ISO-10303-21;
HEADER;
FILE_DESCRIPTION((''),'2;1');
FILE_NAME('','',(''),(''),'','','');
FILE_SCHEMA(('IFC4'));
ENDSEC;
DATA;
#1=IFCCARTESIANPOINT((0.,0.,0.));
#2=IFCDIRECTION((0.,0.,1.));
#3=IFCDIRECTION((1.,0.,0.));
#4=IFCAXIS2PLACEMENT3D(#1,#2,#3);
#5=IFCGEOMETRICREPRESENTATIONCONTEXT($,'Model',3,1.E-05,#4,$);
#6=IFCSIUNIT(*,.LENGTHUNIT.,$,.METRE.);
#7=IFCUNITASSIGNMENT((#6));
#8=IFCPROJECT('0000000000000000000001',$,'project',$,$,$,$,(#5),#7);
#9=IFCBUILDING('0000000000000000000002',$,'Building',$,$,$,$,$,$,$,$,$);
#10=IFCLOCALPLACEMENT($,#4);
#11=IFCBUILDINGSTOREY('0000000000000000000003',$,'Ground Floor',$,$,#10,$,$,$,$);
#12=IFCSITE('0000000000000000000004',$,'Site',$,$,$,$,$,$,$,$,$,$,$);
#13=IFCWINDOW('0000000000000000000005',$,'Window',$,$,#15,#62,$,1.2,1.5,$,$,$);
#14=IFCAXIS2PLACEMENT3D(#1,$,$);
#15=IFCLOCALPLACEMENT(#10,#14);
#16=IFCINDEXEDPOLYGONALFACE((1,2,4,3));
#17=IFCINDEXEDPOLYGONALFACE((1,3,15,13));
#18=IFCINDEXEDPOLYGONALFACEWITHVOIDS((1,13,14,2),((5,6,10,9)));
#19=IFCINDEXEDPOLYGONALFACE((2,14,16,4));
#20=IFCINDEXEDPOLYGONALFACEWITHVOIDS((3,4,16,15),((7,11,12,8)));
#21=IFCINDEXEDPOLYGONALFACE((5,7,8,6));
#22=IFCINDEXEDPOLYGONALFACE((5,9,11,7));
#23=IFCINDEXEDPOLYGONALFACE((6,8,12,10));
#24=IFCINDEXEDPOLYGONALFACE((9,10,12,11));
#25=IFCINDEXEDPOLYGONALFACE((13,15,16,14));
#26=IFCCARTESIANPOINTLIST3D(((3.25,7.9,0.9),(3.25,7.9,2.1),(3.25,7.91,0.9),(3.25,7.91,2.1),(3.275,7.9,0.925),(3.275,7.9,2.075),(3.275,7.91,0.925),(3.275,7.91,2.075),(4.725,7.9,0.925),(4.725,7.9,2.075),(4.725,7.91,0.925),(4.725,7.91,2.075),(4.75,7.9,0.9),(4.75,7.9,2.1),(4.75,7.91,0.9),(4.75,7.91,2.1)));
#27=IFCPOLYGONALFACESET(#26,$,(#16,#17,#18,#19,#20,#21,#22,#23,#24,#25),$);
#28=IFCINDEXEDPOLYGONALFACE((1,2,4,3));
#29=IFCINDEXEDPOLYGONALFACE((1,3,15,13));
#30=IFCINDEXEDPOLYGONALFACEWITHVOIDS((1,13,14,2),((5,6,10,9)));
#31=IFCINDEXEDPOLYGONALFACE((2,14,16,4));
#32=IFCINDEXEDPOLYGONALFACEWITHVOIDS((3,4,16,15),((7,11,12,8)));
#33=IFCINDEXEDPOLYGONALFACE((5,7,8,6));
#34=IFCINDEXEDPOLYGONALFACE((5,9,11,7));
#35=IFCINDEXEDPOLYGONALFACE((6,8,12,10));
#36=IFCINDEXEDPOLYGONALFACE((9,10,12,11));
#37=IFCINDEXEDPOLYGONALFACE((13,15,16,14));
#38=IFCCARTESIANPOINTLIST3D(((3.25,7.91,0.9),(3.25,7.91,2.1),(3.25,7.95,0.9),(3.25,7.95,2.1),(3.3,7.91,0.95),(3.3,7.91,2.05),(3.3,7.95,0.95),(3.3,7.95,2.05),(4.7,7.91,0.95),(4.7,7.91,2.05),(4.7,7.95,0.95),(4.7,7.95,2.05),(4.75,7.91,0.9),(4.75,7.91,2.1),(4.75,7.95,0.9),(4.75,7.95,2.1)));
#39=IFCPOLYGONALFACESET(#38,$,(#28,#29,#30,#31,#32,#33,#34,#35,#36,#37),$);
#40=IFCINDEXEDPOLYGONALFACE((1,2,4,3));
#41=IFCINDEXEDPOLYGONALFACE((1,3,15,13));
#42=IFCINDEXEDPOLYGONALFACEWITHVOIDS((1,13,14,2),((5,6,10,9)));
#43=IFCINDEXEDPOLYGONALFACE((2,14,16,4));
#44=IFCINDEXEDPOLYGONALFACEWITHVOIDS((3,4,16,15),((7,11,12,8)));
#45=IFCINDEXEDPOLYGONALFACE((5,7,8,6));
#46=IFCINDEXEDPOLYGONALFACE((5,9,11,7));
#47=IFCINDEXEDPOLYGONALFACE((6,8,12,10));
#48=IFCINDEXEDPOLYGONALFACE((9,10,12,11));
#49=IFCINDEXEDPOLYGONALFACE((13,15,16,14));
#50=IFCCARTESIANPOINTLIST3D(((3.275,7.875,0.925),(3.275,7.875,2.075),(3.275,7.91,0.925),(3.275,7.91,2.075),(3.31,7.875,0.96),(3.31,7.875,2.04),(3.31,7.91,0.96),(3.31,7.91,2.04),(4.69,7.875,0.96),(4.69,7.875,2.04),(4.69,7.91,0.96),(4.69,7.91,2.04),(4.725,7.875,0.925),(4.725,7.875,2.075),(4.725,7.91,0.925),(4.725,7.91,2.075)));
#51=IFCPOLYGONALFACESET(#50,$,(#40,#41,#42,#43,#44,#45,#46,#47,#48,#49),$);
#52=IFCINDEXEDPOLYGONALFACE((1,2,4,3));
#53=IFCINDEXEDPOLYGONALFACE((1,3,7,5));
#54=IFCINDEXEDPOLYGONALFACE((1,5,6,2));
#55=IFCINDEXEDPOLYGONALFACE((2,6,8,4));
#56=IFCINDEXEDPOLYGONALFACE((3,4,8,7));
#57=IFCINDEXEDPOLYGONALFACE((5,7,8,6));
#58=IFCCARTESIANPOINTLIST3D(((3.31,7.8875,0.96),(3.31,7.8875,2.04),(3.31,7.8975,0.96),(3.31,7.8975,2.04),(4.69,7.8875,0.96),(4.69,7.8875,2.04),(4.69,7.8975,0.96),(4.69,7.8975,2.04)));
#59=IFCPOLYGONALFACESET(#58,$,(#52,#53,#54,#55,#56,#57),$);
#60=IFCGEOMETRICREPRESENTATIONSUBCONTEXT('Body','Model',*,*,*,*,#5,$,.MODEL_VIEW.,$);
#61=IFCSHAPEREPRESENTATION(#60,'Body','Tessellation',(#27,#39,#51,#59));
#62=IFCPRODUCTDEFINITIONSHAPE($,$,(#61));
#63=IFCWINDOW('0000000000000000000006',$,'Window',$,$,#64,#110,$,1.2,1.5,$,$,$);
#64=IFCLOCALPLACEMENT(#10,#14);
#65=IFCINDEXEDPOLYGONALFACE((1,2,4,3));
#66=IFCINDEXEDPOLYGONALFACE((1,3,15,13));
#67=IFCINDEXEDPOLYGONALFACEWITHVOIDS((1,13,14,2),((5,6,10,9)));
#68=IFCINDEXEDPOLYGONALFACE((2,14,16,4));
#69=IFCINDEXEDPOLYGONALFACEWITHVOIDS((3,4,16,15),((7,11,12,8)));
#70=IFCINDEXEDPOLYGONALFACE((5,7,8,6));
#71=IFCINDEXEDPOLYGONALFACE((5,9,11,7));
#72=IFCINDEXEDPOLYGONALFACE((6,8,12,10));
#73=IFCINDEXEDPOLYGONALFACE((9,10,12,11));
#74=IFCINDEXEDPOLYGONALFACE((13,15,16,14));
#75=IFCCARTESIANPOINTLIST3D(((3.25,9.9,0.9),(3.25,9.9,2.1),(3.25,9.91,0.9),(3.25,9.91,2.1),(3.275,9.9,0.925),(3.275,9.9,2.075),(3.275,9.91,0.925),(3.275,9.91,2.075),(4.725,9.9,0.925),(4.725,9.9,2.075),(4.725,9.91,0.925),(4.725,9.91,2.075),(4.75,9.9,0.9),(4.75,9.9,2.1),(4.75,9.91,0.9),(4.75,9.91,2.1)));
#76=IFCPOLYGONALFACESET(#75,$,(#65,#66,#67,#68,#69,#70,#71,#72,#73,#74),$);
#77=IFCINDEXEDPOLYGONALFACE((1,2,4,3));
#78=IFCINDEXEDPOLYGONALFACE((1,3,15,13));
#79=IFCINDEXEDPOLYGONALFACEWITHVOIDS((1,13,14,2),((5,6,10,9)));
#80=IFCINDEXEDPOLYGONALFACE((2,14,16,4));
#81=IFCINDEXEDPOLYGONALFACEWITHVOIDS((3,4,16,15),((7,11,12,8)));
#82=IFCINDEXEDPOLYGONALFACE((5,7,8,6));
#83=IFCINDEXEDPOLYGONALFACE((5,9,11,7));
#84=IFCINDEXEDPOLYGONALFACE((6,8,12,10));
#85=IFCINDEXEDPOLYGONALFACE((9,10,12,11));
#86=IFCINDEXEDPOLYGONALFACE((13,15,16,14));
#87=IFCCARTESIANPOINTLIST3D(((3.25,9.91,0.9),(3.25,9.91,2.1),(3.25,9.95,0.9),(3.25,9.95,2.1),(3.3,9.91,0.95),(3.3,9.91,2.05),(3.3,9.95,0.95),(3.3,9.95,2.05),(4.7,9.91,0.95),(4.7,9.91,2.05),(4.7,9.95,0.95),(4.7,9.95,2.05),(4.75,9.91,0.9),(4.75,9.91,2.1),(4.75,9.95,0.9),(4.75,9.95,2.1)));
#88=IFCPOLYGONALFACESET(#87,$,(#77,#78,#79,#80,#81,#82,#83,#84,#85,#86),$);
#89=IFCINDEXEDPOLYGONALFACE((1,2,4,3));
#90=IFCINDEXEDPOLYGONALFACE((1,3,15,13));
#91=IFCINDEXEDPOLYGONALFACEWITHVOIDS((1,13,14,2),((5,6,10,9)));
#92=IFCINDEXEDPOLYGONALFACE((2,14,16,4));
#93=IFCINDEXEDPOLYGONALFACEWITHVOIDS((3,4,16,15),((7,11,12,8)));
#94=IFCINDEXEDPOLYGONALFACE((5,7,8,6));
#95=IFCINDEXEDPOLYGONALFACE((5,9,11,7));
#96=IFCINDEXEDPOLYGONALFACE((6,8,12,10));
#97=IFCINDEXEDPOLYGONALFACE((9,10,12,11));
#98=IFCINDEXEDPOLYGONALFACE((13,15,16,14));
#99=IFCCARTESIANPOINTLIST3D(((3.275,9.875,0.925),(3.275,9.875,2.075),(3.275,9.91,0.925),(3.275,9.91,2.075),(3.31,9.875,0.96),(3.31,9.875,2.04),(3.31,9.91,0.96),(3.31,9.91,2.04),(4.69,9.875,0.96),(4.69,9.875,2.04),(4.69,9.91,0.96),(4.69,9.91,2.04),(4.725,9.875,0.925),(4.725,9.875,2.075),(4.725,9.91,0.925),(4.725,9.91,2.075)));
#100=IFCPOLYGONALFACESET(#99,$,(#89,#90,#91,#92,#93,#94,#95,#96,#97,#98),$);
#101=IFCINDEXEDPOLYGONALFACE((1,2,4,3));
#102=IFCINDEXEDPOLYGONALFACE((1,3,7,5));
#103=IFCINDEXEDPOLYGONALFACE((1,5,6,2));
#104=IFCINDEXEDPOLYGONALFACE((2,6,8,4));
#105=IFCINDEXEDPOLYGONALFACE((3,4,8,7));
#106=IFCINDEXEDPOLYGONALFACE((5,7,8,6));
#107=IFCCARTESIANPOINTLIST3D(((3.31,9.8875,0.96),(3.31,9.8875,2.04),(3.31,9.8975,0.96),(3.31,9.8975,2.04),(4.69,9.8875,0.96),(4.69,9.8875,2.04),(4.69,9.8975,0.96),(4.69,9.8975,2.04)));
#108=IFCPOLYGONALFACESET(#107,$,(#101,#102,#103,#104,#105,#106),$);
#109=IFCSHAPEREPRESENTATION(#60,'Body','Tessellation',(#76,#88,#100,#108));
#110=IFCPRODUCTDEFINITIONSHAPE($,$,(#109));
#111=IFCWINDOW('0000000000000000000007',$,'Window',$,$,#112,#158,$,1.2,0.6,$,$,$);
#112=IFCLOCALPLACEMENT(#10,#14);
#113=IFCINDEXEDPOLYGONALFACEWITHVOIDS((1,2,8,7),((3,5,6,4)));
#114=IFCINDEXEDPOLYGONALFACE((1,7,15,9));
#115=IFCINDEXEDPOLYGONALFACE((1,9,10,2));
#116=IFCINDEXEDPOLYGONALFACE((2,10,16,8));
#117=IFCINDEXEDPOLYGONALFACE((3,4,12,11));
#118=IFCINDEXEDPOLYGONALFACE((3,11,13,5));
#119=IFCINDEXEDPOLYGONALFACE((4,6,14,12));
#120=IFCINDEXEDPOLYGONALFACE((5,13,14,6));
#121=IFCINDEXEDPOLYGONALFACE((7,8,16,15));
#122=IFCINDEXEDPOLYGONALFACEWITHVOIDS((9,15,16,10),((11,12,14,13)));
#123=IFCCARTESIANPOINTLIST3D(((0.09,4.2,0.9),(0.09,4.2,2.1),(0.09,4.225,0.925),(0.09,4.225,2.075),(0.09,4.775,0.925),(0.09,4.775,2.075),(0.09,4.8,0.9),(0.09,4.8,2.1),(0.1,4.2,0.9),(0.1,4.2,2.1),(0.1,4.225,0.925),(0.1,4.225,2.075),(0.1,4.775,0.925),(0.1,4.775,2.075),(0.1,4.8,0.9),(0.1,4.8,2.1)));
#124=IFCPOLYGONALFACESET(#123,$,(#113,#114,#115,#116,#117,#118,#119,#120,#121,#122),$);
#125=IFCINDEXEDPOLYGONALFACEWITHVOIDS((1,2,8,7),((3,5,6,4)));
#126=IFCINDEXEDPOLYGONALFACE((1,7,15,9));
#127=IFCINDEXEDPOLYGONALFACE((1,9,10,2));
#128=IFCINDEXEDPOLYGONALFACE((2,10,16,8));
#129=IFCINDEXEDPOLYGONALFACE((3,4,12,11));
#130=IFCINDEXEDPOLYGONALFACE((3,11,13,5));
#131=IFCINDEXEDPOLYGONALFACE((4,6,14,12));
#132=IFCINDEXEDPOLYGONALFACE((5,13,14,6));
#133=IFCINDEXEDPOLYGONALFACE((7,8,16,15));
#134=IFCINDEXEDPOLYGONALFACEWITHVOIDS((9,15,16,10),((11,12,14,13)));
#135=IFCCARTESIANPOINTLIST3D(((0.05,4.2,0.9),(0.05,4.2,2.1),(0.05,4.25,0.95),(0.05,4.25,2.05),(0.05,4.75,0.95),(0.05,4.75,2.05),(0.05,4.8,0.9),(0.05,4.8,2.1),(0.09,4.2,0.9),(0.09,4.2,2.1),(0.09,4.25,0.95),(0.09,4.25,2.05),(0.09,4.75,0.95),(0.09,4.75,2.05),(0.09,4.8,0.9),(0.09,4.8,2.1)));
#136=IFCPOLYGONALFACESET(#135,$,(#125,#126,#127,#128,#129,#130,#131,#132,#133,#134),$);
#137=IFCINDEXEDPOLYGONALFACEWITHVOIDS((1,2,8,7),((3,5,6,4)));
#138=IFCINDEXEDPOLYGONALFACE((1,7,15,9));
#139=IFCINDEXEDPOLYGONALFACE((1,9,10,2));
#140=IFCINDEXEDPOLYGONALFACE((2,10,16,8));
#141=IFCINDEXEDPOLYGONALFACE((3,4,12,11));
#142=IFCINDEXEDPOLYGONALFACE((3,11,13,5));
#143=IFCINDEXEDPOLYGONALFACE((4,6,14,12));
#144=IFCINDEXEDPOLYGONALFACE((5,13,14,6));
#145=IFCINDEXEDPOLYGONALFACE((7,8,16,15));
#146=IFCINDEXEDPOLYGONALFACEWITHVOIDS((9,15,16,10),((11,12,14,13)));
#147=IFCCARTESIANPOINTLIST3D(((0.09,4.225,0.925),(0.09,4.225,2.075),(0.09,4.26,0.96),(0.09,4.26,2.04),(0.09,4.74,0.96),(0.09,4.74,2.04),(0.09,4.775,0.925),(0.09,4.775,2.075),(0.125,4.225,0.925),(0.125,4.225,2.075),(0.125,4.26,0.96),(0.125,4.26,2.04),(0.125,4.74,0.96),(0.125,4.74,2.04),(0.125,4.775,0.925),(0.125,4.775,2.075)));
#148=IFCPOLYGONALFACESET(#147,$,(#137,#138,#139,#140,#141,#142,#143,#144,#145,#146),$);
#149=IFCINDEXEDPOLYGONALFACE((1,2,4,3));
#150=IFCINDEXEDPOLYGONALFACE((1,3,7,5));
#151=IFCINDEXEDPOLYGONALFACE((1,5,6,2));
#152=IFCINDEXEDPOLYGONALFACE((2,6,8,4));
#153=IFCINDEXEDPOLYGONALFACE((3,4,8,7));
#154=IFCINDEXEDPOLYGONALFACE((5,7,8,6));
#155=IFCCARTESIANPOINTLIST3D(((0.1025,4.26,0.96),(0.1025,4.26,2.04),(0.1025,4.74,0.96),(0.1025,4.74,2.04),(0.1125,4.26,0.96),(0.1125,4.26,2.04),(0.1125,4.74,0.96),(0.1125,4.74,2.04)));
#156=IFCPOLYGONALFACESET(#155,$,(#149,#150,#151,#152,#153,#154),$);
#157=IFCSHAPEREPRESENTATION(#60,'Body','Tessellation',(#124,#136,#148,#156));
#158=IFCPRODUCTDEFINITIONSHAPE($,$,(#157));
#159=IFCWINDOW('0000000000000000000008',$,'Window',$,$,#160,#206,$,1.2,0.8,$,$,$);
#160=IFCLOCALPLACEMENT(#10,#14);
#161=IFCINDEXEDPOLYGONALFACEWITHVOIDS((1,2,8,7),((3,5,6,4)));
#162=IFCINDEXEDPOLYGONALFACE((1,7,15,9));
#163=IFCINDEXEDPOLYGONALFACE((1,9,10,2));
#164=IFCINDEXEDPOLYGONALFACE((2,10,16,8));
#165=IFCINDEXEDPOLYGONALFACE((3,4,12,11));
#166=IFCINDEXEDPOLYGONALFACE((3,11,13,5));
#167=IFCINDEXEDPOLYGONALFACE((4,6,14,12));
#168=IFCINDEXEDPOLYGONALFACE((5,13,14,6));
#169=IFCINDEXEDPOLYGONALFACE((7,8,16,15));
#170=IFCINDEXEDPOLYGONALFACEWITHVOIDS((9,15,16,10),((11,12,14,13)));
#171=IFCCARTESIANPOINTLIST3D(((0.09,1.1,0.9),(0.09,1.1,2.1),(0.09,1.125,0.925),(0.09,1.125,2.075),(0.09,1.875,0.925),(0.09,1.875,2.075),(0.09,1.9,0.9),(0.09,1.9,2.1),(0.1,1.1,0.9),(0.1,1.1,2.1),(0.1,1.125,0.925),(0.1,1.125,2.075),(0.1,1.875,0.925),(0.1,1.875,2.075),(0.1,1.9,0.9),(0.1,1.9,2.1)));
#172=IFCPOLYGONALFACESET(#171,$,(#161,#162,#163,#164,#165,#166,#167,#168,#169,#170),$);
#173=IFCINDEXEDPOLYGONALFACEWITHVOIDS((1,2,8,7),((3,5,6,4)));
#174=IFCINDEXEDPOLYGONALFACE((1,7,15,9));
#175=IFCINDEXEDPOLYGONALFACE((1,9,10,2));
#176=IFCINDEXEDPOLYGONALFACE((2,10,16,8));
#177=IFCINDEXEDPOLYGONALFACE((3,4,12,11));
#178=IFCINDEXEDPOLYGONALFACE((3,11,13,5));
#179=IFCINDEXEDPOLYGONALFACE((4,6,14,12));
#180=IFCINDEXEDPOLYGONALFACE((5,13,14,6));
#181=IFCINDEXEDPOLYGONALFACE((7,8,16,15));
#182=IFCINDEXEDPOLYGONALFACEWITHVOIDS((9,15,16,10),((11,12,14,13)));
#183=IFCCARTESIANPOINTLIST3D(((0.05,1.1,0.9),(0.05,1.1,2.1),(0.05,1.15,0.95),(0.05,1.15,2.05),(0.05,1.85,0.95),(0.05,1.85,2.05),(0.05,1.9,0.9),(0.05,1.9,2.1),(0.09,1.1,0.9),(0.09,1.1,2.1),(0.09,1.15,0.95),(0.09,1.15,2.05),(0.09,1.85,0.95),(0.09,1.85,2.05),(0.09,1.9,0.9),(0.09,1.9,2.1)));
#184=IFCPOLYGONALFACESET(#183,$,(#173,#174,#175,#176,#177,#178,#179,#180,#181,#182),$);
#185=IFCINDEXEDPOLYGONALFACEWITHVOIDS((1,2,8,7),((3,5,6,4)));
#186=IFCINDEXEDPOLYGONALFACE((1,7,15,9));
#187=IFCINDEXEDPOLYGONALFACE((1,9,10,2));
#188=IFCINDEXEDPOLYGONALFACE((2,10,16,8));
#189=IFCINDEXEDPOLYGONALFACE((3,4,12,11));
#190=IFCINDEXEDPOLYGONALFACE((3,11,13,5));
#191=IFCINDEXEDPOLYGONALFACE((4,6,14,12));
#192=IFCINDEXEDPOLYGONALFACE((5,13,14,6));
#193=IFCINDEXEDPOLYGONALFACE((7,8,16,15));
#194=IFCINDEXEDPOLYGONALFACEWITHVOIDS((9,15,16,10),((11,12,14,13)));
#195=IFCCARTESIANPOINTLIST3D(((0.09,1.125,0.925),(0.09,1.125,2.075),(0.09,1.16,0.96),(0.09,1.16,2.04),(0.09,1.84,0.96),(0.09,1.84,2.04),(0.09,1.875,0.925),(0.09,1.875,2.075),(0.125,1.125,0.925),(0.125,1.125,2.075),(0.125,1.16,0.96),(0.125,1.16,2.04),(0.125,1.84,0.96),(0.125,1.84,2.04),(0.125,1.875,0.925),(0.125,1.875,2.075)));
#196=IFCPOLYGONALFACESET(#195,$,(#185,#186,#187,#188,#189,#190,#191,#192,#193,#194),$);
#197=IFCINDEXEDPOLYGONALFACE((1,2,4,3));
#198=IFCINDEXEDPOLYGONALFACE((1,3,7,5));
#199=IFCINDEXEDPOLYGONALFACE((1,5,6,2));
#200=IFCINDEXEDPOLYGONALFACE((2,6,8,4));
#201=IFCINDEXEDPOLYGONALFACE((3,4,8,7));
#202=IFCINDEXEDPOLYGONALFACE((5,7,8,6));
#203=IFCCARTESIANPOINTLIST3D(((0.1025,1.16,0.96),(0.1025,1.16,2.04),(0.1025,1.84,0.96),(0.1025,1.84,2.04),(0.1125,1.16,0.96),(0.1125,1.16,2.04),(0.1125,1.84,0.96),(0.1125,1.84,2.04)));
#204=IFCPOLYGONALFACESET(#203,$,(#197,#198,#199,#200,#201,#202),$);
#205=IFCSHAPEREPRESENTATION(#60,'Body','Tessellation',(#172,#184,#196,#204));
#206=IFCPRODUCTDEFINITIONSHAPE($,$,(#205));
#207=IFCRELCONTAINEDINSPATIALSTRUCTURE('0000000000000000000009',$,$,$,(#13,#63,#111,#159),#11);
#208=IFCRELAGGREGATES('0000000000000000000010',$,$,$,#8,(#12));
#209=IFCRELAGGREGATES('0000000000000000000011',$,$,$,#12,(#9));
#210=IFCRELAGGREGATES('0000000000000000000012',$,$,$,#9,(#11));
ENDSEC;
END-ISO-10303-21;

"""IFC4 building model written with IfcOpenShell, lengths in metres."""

from ifc_helpers import new_model, si_unit, frame, origin_with_axes, place, context, subcontext, project, spatial, line, indexed_curve, outline, extrude, element, save


model = new_model("IFC4")

# Units and contexts
model_context = context("Model", 3, precision=1e-05, world=origin_with_axes())
body_context = subcontext(model_context, "Body", "Model", "MODEL_VIEW")
ifc_project = project(units=[si_unit("LENGTHUNIT", "METRE")], contexts=[model_context])

# Site, building, storey
site = spatial("IfcSite", under=ifc_project, Name="Site")
building = spatial("IfcBuilding", under=site, Name="Building")
storey_placement = place(None, origin_with_axes())
storey = spatial("IfcBuildingStorey", under=building, at=storey_placement, Name="Ground Floor")

# Windows
for number, where, z_axis, x_axis, name in (
    (1, (4.75, 8.0, 0.9), (0.0, 0.0, 1.0), (-1.0, 0.0, 0.0), "Window"),
    (2, (4.75, 10.0, 0.9), (0.0, 0.0, 1.0), (-1.0, 0.0, 0.0), "Window"),
):
    element("IfcWindow", number, at=place(storey_placement, frame(where, z_axis=z_axis, x_axis=x_axis)), inside=storey, Name=name, OverallHeight=1.2, OverallWidth=1.5, context=body_context, shape_type="SweptSolid", body=[
        extrude(outline(indexed_curve([(0.0, 0.0), (1.5, 0.0), (1.5, 1.2), (0.0, 1.2)], segments=[line(1, 2, 3, 4, 1)]), holes=[indexed_curve([(0.025, 0.025), (1.475, 0.025), (1.475, 1.175), (0.025, 1.175)], segments=[line(1, 2, 3, 4, 1)])]), frame((0.0, 0.09, 0.0), z_axis=(0.0, -1.0, 0.0), x_axis=(1.0, 0.0, 0.0)), (0.0, 0.0, -1.0), 0.01),
        extrude(outline(indexed_curve([(0.0, 0.0), (1.5, 0.0), (1.5, 1.2), (0.0, 1.2)], segments=[line(1, 2, 3, 4, 1)]), holes=[indexed_curve([(0.05, 0.05), (1.45, 0.05), (1.45, 1.15), (0.05, 1.15)], segments=[line(1, 2, 3, 4, 1)])]), frame((0.0, 0.05, 0.0), z_axis=(0.0, -1.0, 0.0), x_axis=(1.0, 0.0, 0.0)), (0.0, 0.0, -1.0), 0.04),
        extrude(outline(indexed_curve([(0.0, 0.0), (1.45, 0.0), (1.45, 1.15), (0.0, 1.15)], segments=[line(1, 2, 3, 4, 1)]), holes=[indexed_curve([(0.035, 0.035), (1.415, 0.035), (1.415, 1.115), (0.035, 1.115)], segments=[line(1, 2, 3, 4, 1)])]), frame((0.025, 0.09, 0.025), z_axis=(0.0, -1.0, 0.0), x_axis=(1.0, 0.0, 0.0)), (0.0, 0.0, -1.0), 0.035),
        extrude(outline(indexed_curve([(0.035, 0.035), (1.415, 0.035), (1.415, 1.115), (0.035, 1.115)], segments=[line(1, 2, 3, 4, 1)])), frame((0.025, 0.1025, 0.025), z_axis=(0.0, -1.0, 0.0), x_axis=(1.0, 0.0, 0.0)), (0.0, 0.0, -1.0), 0.01),
    ])
window_1_placement = place(storey_placement, frame((0.0, 4.8, 0.9), z_axis=(0.0, 0.0, 1.0), x_axis=(0.0, -1.0, 0.0)))
element("IfcWindow", 3, at=window_1_placement, inside=storey, Name="Window", OverallHeight=1.2, OverallWidth=0.6, context=body_context, shape_type="SweptSolid", body=[
    extrude(outline(indexed_curve([(0.0, 0.0), (0.6, 0.0), (0.6, 1.2), (0.0, 1.2)], segments=[line(1, 2, 3, 4, 1)]), holes=[indexed_curve([(0.025, 0.025), (0.575, 0.025), (0.575, 1.175), (0.025, 1.175)], segments=[line(1, 2, 3, 4, 1)])]), frame((0.0, 0.09, 0.0), z_axis=(0.0, -1.0, 0.0), x_axis=(1.0, 0.0, 0.0)), (0.0, 0.0, -1.0), 0.01),
    extrude(outline(indexed_curve([(0.0, 0.0), (0.6, 0.0), (0.6, 1.2), (0.0, 1.2)], segments=[line(1, 2, 3, 4, 1)]), holes=[indexed_curve([(0.05, 0.05), (0.55, 0.05), (0.55, 1.15), (0.05, 1.15)], segments=[line(1, 2, 3, 4, 1)])]), frame((0.0, 0.05, 0.0), z_axis=(0.0, -1.0, 0.0), x_axis=(1.0, 0.0, 0.0)), (0.0, 0.0, -1.0), 0.04),
    extrude(outline(indexed_curve([(0.0, 0.0), (0.55, 0.0), (0.55, 1.15), (0.0, 1.15)], segments=[line(1, 2, 3, 4, 1)]), holes=[indexed_curve([(0.035, 0.035), (0.515, 0.035), (0.515, 1.115), (0.035, 1.115)], segments=[line(1, 2, 3, 4, 1)])]), frame((0.025, 0.09, 0.025), z_axis=(0.0, -1.0, 0.0), x_axis=(1.0, 0.0, 0.0)), (0.0, 0.0, -1.0), 0.035),
    extrude(outline(indexed_curve([(0.035, 0.035), (0.515, 0.035), (0.515, 1.115), (0.035, 1.115)], segments=[line(1, 2, 3, 4, 1)])), frame((0.025, 0.1025, 0.025), z_axis=(0.0, -1.0, 0.0), x_axis=(1.0, 0.0, 0.0)), (0.0, 0.0, -1.0), 0.01),
])
window_2_placement = place(storey_placement, frame((0.0, 1.9, 0.9), z_axis=(0.0, 0.0, 1.0), x_axis=(0.0, -1.0, 0.0)))
element("IfcWindow", 4, at=window_2_placement, inside=storey, Name="Window", OverallHeight=1.2, OverallWidth=0.8, context=body_context, shape_type="SweptSolid", body=[
    extrude(outline(indexed_curve([(0.0, 0.0), (0.8, 0.0), (0.8, 1.2), (0.0, 1.2)], segments=[line(1, 2, 3, 4, 1)]), holes=[indexed_curve([(0.025, 0.025), (0.775, 0.025), (0.775, 1.175), (0.025, 1.175)], segments=[line(1, 2, 3, 4, 1)])]), frame((0.0, 0.09, 0.0), z_axis=(0.0, -1.0, 0.0), x_axis=(1.0, 0.0, 0.0)), (0.0, 0.0, -1.0), 0.01),
    extrude(outline(indexed_curve([(0.0, 0.0), (0.8, 0.0), (0.8, 1.2), (0.0, 1.2)], segments=[line(1, 2, 3, 4, 1)]), holes=[indexed_curve([(0.05, 0.05), (0.75, 0.05), (0.75, 1.15), (0.05, 1.15)], segments=[line(1, 2, 3, 4, 1)])]), frame((0.0, 0.05, 0.0), z_axis=(0.0, -1.0, 0.0), x_axis=(1.0, 0.0, 0.0)), (0.0, 0.0, -1.0), 0.04),
    extrude(outline(indexed_curve([(0.0, 0.0), (0.75, 0.0), (0.75, 1.15), (0.0, 1.15)], segments=[line(1, 2, 3, 4, 1)]), holes=[indexed_curve([(0.035, 0.035), (0.715, 0.035), (0.715, 1.115), (0.035, 1.115)], segments=[line(1, 2, 3, 4, 1)])]), frame((0.025, 0.09, 0.025), z_axis=(0.0, -1.0, 0.0), x_axis=(1.0, 0.0, 0.0)), (0.0, 0.0, -1.0), 0.035),
    extrude(outline(indexed_curve([(0.035, 0.035), (0.715, 0.035), (0.715, 1.115), (0.035, 1.115)], segments=[line(1, 2, 3, 4, 1)])), frame((0.025, 0.1025, 0.025), z_axis=(0.0, -1.0, 0.0), x_axis=(1.0, 0.0, 0.0)), (0.0, 0.0, -1.0), 0.01),
])

save(model, "model.ifc")
